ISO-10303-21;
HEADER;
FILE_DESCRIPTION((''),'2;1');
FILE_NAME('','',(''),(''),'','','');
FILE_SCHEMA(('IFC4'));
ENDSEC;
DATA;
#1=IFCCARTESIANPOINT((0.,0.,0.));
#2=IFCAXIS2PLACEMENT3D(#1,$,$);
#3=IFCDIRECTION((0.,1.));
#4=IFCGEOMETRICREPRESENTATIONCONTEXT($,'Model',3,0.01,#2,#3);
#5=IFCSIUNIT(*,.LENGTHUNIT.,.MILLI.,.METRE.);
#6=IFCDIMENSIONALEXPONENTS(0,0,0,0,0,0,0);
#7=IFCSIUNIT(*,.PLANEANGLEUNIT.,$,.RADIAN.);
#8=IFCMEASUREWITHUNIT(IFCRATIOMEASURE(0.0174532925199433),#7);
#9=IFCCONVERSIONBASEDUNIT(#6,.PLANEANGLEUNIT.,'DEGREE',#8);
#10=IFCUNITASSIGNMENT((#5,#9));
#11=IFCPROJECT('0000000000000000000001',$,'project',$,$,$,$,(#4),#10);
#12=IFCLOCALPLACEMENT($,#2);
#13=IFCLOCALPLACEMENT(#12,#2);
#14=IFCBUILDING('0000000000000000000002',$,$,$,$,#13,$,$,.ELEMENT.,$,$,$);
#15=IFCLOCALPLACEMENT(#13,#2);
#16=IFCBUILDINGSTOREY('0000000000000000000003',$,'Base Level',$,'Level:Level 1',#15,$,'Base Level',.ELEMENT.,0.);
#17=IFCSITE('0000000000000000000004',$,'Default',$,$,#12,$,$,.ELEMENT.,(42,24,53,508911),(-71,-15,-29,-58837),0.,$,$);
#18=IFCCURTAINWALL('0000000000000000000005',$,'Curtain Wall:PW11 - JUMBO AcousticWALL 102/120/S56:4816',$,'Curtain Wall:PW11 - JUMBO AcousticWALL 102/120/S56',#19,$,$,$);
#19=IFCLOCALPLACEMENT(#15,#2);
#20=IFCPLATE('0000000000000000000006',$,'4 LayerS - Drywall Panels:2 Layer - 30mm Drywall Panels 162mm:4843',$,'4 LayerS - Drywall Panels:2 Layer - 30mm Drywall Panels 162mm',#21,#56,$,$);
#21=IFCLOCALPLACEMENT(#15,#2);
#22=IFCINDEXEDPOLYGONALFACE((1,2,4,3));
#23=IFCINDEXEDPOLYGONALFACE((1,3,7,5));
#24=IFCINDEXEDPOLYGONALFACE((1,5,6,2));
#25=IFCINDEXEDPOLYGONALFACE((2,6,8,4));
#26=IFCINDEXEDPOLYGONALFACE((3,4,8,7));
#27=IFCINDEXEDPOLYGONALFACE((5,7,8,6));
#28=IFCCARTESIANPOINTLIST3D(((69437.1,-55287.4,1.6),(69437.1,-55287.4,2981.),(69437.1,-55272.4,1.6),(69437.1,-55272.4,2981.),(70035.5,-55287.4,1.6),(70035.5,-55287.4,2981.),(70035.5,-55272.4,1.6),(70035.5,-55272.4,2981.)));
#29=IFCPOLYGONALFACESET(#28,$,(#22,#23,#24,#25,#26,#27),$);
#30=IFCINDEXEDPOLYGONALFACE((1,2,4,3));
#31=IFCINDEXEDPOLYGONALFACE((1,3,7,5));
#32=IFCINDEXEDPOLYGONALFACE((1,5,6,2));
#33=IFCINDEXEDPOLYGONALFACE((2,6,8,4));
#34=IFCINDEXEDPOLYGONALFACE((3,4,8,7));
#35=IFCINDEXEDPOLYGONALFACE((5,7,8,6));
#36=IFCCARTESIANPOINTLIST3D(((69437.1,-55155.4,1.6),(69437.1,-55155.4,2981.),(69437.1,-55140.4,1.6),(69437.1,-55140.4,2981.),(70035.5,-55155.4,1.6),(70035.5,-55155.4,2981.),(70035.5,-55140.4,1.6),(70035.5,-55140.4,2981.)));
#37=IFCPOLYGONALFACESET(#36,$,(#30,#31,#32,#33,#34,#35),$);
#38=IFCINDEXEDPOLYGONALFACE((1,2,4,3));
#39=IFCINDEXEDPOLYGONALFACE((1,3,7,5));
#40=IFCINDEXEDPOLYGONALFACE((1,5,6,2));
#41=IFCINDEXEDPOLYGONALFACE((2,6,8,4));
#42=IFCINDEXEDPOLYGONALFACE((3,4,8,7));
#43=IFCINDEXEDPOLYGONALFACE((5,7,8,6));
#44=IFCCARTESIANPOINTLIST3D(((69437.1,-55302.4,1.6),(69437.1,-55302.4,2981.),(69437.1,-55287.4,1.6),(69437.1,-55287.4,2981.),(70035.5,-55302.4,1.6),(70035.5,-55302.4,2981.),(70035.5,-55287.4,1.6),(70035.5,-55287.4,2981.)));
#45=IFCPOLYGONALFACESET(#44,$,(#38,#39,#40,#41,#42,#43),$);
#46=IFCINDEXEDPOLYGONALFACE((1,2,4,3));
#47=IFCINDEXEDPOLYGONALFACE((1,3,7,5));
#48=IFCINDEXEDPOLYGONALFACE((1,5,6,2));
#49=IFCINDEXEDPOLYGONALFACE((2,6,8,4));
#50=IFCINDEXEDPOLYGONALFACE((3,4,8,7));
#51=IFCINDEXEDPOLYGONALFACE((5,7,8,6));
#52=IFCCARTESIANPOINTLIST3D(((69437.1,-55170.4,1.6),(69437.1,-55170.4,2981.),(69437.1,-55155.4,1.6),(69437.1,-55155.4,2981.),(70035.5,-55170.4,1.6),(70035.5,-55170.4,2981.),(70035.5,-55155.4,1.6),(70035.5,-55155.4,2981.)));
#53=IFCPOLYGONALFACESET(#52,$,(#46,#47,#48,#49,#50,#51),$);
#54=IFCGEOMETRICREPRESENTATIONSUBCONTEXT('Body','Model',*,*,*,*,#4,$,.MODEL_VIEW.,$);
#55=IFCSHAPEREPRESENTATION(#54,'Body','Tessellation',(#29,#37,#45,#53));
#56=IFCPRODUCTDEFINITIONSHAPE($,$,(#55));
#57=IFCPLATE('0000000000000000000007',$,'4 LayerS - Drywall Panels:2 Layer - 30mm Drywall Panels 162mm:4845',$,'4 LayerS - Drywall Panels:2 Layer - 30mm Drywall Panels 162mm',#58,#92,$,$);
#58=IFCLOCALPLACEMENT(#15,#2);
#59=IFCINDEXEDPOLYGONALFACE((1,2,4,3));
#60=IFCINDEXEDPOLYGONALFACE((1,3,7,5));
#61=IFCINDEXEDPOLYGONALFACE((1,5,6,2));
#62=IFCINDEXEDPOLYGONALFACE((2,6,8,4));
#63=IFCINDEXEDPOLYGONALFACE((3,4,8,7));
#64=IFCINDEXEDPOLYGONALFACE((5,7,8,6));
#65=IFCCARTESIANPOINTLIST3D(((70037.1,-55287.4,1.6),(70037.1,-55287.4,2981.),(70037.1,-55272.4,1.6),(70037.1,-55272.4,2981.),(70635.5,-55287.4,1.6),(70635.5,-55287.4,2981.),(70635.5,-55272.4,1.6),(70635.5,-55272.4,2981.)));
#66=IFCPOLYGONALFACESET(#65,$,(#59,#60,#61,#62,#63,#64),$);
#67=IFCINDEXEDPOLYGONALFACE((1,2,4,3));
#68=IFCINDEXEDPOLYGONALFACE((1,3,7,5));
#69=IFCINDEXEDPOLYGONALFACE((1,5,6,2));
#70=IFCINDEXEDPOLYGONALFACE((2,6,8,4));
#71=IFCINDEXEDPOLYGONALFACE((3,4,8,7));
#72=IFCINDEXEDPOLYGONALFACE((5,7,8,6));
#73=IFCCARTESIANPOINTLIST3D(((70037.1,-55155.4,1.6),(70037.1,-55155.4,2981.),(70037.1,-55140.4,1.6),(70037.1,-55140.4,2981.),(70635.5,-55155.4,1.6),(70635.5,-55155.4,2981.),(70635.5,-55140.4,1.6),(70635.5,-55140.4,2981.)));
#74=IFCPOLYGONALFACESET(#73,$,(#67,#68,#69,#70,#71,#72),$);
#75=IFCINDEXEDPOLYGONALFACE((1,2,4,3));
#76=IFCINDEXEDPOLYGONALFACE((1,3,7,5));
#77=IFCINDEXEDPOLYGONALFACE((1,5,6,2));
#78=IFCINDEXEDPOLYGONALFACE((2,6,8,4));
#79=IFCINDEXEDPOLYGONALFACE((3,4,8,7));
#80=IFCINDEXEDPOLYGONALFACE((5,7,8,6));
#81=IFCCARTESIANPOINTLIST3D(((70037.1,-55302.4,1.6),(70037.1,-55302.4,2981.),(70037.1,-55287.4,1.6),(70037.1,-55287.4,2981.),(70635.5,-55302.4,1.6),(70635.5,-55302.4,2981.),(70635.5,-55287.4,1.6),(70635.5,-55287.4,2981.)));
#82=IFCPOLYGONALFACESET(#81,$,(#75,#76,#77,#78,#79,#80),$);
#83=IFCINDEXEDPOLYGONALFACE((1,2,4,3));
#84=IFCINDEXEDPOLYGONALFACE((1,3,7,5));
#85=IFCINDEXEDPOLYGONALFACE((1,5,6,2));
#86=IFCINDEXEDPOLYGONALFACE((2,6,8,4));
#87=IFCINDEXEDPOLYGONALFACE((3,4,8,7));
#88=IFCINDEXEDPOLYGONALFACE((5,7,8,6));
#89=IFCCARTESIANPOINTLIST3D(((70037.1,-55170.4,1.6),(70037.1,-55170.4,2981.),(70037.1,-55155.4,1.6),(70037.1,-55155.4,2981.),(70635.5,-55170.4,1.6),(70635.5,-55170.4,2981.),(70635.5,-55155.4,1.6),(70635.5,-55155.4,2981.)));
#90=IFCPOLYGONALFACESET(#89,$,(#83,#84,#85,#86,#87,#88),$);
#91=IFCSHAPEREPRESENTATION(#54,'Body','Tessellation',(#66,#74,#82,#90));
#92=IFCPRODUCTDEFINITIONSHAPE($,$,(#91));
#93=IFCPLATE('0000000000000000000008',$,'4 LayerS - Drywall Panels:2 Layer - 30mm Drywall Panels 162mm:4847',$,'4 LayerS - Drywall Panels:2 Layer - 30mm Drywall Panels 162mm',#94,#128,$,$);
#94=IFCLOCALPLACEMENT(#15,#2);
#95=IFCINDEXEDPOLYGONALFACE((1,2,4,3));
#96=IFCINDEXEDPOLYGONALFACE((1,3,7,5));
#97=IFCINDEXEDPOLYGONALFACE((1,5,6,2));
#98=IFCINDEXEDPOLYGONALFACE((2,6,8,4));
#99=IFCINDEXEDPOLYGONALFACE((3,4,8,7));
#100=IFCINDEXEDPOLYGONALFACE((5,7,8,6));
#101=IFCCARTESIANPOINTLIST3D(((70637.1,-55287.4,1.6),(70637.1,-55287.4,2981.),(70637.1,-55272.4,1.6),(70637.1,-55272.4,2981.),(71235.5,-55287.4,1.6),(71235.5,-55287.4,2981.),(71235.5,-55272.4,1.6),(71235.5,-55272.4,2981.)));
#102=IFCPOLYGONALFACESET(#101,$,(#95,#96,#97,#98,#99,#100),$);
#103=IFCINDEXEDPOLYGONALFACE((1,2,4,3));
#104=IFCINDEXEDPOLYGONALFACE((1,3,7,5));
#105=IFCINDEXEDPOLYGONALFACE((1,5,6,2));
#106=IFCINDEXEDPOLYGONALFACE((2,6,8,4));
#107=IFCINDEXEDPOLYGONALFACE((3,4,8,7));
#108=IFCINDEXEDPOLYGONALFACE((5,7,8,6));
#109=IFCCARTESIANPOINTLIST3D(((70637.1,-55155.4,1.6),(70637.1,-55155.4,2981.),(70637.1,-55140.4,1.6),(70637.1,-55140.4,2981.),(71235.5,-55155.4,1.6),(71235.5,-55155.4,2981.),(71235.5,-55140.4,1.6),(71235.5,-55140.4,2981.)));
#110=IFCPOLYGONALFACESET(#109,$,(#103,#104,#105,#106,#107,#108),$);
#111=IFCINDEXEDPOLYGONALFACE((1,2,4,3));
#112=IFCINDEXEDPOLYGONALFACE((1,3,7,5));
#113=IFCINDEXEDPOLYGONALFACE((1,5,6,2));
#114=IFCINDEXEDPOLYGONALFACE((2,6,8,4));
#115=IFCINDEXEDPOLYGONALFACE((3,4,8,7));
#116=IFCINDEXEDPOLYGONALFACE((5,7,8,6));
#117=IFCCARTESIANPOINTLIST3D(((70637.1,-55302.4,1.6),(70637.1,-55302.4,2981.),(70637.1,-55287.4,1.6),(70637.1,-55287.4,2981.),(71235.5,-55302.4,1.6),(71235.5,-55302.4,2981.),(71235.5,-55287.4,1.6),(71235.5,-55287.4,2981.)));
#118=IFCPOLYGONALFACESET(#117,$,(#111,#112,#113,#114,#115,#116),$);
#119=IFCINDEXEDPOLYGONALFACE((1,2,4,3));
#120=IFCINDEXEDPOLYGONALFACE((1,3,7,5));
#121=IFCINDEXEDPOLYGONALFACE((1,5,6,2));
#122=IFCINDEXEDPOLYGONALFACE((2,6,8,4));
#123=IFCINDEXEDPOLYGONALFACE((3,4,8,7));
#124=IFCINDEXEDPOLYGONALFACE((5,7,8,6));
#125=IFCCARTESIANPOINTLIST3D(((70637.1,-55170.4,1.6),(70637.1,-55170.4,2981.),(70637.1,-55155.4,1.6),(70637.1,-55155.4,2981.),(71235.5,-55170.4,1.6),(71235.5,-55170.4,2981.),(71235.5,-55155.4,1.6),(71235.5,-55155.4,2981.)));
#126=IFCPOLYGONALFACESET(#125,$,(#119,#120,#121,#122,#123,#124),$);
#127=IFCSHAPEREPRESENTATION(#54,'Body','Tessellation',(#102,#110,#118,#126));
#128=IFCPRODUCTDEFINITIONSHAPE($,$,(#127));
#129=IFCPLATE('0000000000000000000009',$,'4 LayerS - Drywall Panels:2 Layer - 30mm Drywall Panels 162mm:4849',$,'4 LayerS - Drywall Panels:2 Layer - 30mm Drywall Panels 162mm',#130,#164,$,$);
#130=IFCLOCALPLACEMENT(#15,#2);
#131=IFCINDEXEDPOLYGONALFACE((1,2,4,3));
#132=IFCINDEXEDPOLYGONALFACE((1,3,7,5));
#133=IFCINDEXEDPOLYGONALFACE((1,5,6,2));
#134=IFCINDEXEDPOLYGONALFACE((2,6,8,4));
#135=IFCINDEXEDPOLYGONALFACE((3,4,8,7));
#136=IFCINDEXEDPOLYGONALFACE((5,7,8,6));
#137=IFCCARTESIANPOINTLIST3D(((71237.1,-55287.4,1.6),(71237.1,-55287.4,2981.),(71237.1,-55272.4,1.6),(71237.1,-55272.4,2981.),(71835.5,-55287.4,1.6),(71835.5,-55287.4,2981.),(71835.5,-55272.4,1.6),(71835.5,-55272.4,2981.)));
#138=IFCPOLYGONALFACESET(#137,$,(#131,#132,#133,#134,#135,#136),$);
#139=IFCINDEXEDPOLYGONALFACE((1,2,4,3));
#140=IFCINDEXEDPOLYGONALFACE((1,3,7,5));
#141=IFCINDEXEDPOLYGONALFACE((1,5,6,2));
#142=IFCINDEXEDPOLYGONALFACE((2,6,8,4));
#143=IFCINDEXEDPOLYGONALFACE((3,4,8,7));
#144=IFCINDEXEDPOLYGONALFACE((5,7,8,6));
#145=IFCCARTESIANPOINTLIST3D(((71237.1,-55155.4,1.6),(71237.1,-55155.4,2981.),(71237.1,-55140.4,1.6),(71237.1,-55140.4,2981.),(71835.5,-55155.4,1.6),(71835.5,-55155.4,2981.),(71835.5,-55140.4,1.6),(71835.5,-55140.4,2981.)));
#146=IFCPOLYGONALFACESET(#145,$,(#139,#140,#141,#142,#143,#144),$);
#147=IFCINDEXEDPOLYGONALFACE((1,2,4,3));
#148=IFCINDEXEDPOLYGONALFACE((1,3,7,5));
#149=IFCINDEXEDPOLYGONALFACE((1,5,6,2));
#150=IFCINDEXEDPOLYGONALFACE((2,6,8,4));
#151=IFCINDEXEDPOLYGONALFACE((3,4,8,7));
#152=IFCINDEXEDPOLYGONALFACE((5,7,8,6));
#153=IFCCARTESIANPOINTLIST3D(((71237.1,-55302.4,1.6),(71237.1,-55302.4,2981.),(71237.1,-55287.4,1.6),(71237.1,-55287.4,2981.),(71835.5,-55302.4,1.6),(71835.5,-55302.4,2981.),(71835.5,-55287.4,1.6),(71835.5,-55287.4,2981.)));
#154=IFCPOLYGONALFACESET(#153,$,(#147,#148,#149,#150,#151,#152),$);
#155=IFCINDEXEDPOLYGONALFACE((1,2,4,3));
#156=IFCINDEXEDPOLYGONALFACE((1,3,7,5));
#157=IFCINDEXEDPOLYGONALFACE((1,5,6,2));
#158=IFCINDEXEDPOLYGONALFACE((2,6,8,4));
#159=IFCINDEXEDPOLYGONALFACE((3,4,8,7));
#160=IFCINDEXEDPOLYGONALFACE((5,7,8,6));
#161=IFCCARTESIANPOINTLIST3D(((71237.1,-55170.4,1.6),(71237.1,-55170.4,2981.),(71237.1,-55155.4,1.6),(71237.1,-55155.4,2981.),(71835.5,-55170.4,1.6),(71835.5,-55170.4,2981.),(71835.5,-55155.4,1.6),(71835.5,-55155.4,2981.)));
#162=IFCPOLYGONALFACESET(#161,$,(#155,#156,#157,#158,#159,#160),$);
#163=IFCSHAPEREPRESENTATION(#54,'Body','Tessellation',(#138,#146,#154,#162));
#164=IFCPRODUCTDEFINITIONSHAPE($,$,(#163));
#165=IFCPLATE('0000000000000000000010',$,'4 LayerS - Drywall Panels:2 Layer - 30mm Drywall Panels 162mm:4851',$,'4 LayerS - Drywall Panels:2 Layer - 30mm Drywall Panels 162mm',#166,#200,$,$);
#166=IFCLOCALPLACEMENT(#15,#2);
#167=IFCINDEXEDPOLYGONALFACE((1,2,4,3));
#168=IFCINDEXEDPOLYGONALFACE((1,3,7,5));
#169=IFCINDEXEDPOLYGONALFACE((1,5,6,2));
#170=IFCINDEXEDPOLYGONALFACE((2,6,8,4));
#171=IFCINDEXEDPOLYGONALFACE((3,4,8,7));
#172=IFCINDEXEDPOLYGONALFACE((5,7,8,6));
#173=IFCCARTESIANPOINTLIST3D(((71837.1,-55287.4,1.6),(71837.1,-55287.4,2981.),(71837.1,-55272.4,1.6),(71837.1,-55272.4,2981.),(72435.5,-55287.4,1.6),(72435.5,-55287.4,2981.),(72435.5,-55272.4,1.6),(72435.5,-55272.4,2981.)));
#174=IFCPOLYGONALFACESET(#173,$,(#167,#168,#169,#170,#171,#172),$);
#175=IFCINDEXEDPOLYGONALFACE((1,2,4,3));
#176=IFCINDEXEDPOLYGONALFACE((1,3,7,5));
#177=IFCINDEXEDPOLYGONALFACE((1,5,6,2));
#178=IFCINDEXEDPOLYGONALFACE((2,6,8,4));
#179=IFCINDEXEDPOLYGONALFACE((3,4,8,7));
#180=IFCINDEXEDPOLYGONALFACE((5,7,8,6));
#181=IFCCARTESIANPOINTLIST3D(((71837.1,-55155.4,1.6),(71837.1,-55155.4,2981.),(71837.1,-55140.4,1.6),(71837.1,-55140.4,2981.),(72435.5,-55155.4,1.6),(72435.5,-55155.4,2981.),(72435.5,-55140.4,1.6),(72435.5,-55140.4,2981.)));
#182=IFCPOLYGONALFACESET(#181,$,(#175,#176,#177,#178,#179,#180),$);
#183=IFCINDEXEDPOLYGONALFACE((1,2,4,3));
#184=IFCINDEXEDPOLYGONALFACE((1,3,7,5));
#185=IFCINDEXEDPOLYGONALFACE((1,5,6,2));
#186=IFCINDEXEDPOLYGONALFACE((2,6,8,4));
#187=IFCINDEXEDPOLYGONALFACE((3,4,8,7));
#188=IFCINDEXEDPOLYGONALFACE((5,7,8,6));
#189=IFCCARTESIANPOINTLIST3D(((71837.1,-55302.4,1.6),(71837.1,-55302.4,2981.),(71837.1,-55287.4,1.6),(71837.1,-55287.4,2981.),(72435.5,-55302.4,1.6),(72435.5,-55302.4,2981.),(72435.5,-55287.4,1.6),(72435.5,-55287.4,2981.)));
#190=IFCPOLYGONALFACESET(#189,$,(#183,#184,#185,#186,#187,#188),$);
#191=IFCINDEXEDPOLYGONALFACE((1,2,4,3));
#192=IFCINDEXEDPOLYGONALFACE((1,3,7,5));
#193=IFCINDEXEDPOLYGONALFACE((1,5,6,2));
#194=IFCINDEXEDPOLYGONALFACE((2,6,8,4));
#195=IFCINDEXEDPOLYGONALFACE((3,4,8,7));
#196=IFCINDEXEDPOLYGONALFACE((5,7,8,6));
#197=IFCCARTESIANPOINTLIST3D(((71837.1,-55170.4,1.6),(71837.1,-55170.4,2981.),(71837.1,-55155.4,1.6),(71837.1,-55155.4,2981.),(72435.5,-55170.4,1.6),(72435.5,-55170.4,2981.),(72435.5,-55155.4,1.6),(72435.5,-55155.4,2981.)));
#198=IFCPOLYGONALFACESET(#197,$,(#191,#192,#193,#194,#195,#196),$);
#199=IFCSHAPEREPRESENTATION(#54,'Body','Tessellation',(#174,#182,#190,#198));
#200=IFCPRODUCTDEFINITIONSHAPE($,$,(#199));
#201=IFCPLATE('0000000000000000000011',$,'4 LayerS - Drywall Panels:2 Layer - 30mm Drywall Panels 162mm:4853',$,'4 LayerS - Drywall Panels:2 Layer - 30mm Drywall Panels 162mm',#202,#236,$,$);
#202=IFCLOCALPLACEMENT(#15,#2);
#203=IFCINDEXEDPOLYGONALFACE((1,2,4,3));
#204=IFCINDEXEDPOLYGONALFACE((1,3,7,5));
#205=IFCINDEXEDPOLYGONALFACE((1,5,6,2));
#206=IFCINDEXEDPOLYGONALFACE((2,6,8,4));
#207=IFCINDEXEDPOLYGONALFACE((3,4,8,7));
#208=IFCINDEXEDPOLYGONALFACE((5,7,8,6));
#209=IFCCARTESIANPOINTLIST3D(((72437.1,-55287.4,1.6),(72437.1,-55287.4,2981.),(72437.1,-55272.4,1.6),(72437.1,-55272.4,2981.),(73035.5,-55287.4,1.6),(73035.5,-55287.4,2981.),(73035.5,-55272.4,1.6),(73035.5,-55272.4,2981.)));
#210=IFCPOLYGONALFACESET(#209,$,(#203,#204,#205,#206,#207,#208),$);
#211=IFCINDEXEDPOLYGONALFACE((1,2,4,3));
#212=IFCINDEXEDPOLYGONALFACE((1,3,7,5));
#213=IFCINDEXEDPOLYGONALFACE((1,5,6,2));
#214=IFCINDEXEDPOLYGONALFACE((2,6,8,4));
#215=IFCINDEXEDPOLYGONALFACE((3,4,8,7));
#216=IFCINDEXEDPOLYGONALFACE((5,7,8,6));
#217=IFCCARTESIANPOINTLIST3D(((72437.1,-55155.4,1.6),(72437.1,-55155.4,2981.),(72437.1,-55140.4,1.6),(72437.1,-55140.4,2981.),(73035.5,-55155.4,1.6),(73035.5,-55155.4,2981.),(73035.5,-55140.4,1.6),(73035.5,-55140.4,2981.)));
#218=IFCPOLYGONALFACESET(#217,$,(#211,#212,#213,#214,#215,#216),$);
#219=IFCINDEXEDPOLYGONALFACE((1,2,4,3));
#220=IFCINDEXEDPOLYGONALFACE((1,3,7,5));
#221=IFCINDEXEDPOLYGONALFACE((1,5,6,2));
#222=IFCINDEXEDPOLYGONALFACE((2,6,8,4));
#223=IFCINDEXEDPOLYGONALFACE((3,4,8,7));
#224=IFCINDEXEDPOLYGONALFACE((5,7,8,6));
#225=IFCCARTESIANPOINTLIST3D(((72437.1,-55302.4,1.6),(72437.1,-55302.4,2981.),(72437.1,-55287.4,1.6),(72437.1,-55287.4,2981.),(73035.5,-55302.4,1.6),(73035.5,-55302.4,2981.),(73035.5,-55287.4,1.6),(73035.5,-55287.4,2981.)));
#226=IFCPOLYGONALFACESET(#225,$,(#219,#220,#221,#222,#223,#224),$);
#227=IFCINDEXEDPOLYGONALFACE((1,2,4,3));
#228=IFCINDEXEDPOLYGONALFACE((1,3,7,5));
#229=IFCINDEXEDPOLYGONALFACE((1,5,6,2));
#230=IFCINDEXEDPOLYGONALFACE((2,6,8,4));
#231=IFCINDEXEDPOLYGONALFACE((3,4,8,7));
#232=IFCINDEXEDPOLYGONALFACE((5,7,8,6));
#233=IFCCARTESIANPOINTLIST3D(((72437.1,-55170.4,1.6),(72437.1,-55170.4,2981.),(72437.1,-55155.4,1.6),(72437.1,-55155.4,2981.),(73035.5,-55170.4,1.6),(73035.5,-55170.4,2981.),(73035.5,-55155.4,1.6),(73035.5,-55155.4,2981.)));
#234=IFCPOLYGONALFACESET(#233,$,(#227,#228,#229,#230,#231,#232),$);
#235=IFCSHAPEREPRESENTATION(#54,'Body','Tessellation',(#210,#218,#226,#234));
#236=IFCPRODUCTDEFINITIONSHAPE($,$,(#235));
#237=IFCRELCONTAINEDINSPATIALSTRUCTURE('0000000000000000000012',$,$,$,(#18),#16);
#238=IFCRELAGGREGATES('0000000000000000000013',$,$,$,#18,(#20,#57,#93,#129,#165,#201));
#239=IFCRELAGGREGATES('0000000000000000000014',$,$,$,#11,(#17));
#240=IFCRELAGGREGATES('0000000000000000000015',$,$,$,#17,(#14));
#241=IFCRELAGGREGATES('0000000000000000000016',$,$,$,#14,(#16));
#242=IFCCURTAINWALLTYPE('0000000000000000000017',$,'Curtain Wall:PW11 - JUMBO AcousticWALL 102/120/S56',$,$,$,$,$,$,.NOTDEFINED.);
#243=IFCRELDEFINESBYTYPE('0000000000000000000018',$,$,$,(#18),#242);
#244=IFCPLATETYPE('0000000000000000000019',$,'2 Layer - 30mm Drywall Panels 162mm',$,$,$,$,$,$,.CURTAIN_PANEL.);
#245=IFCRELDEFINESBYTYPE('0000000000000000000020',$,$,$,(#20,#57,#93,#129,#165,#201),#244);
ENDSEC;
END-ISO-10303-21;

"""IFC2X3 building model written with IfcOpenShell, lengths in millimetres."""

from ifc_helpers import new_model, entity, si_unit, converted_unit, direction, frame, frame_2d, origin, origin_2d_with_axis, place, context, subcontext, project, spatial, rectangle, extrude, source, transform, mapped, type_object, type_shapes, element, aggregate, save


model = new_model("IFC2X3")

# Units and contexts
model_context = context("Model", 3, precision=0.01, world=origin(), true_north=direction((0.0, 1.0)))
body_context = subcontext(model_context, "Body", "Model", "MODEL_VIEW")
ifc_project = project(units=[si_unit("LENGTHUNIT", "METRE", prefix="MILLI"), converted_unit("PLANEANGLEUNIT", "DEGREE", entity("IfcRatioMeasure", 0.0174532925199433), si_unit("PLANEANGLEUNIT", "RADIAN"), dimensions=[0, 0, 0, 0, 0, 0, 0])], contexts=[model_context])

# Site, building, storey
site_placement = place(None, origin())
site = spatial("IfcSite", under=ifc_project, at=site_placement, Name="Default", CompositionType="ELEMENT", RefLatitude=(42, 24, 53, 508911), RefLongitude=(-71, -15, -29, -58837), RefElevation=0.0)
building_placement = place(site_placement, origin())
building = spatial("IfcBuilding", under=site, at=building_placement, CompositionType="ELEMENT")
storey_placement = place(building_placement, origin())
storey = spatial("IfcBuildingStorey", under=building, at=storey_placement, Name="Base Level", ObjectType="Level:Level 1", LongName="Base Level", CompositionType="ELEMENT", Elevation=0.0)

# Curtain wall, plates
curtain_wall_type = type_object("IfcCurtainWallType", Name="Curtain Wall:PW11 - JUMBO AcousticWALL 102/120/S56", PredefinedType="NOTDEFINED")
curtain_wall_placement = place(building_placement, origin())
curtain_wall = element("IfcCurtainWall", 1, at=curtain_wall_placement, inside=storey, type_object=curtain_wall_type, Name="Curtain Wall:PW11 - JUMBO AcousticWALL 102/120/S56:4816", ObjectType="Curtain Wall:PW11 - JUMBO AcousticWALL 102/120/S56")
plate_type = type_object("IfcPlateType", Name="2 Layer - 30mm Drywall Panels 162mm", PredefinedType="CURTAIN_PANEL")
shared_shape_1 = source(origin(), body_context, "Body", "SweptSolid", [
    extrude(rectangle(XDim=15.0, YDim=598.4, at=origin_2d_with_axis()), frame((0.0, -58.5, 0.0), z_axis=(0.0, 0.0, 1.0), x_axis=(0.0, 1.0, 0.0)), (0.0, 0.0, 1.0), 2979.4),
    extrude(rectangle(XDim=15.0, YDim=598.4, at=frame_2d((0.0, 0.0), x_axis=(1.0, 0.0))), frame((0.0, 73.5, 0.0), z_axis=(0.0, 0.0, 1.0), x_axis=(0.0, 1.0, 0.0)), (0.0, 0.0, 1.0), 2979.4),
    extrude(rectangle(XDim=598.4, YDim=15.0, at=origin_2d_with_axis()), frame((0.0, -73.5, 0.0), z_axis=(0.0, 0.0, 1.0), x_axis=(-1.0, 0.0, 0.0)), (0.0, 0.0, 1.0), 2979.4),
    extrude(rectangle(XDim=15.0, YDim=598.4, at=frame_2d((0.0, 0.0), x_axis=(1.0, 0.0))), frame((0.0, 58.5, 0.0), z_axis=(0.0, 0.0, 1.0), x_axis=(0.0, 1.0, 0.0)), (0.0, 0.0, 1.0), 2979.4),
])
type_shapes(plate_type, [shared_shape_1])
plate_1_placement = place(curtain_wall_placement, frame((69736.3, -55221.4, 1.6)))
plate_1 = element("IfcPlate", 2, at=plate_1_placement, type_object=plate_type, Name="4 LayerS - Drywall Panels:2 Layer - 30mm Drywall Panels 162mm:4843", ObjectType="4 LayerS - Drywall Panels:2 Layer - 30mm Drywall Panels 162mm", context=body_context, shape_type="MappedRepresentation", body=[
    mapped(shared_shape_1, transform((0.0, 0.0, 0.0), scale=1.0)),
])
plate_2_placement = place(curtain_wall_placement, frame((70336.3, -55221.4, 1.6)))
plate_2 = element("IfcPlate", 3, at=plate_2_placement, type_object=plate_type, Name="4 LayerS - Drywall Panels:2 Layer - 30mm Drywall Panels 162mm:4845", ObjectType="4 LayerS - Drywall Panels:2 Layer - 30mm Drywall Panels 162mm", context=body_context, shape_type="MappedRepresentation", body=[
    mapped(shared_shape_1, transform((0.0, 0.0, 0.0), scale=1.0)),
])
plate_3_placement = place(curtain_wall_placement, frame((70936.3, -55221.4, 1.6)))
plate_3 = element("IfcPlate", 4, at=plate_3_placement, type_object=plate_type, Name="4 LayerS - Drywall Panels:2 Layer - 30mm Drywall Panels 162mm:4847", ObjectType="4 LayerS - Drywall Panels:2 Layer - 30mm Drywall Panels 162mm", context=body_context, shape_type="MappedRepresentation", body=[
    mapped(shared_shape_1, transform((0.0, 0.0, 0.0), scale=1.0)),
])
plate_4_placement = place(curtain_wall_placement, frame((71536.3, -55221.4, 1.6)))
plate_4 = element("IfcPlate", 5, at=plate_4_placement, type_object=plate_type, Name="4 LayerS - Drywall Panels:2 Layer - 30mm Drywall Panels 162mm:4849", ObjectType="4 LayerS - Drywall Panels:2 Layer - 30mm Drywall Panels 162mm", context=body_context, shape_type="MappedRepresentation", body=[
    mapped(shared_shape_1, transform((0.0, 0.0, 0.0), scale=1.0)),
])
plate_5_placement = place(curtain_wall_placement, frame((72136.3, -55221.4, 1.6)))
plate_5 = element("IfcPlate", 6, at=plate_5_placement, type_object=plate_type, Name="4 LayerS - Drywall Panels:2 Layer - 30mm Drywall Panels 162mm:4851", ObjectType="4 LayerS - Drywall Panels:2 Layer - 30mm Drywall Panels 162mm", context=body_context, shape_type="MappedRepresentation", body=[
    mapped(shared_shape_1, transform((0.0, 0.0, 0.0), scale=1.0)),
])
plate_6_placement = place(curtain_wall_placement, frame((72736.3, -55221.4, 1.6)))
plate_6 = element("IfcPlate", 7, at=plate_6_placement, type_object=plate_type, Name="4 LayerS - Drywall Panels:2 Layer - 30mm Drywall Panels 162mm:4853", ObjectType="4 LayerS - Drywall Panels:2 Layer - 30mm Drywall Panels 162mm", context=body_context, shape_type="MappedRepresentation", body=[
    mapped(shared_shape_1, transform((0.0, 0.0, 0.0), scale=1.0)),
])
aggregate(curtain_wall, [plate_1, plate_2, plate_3, plate_4, plate_5, plate_6])

save(model, "model.ifc")
